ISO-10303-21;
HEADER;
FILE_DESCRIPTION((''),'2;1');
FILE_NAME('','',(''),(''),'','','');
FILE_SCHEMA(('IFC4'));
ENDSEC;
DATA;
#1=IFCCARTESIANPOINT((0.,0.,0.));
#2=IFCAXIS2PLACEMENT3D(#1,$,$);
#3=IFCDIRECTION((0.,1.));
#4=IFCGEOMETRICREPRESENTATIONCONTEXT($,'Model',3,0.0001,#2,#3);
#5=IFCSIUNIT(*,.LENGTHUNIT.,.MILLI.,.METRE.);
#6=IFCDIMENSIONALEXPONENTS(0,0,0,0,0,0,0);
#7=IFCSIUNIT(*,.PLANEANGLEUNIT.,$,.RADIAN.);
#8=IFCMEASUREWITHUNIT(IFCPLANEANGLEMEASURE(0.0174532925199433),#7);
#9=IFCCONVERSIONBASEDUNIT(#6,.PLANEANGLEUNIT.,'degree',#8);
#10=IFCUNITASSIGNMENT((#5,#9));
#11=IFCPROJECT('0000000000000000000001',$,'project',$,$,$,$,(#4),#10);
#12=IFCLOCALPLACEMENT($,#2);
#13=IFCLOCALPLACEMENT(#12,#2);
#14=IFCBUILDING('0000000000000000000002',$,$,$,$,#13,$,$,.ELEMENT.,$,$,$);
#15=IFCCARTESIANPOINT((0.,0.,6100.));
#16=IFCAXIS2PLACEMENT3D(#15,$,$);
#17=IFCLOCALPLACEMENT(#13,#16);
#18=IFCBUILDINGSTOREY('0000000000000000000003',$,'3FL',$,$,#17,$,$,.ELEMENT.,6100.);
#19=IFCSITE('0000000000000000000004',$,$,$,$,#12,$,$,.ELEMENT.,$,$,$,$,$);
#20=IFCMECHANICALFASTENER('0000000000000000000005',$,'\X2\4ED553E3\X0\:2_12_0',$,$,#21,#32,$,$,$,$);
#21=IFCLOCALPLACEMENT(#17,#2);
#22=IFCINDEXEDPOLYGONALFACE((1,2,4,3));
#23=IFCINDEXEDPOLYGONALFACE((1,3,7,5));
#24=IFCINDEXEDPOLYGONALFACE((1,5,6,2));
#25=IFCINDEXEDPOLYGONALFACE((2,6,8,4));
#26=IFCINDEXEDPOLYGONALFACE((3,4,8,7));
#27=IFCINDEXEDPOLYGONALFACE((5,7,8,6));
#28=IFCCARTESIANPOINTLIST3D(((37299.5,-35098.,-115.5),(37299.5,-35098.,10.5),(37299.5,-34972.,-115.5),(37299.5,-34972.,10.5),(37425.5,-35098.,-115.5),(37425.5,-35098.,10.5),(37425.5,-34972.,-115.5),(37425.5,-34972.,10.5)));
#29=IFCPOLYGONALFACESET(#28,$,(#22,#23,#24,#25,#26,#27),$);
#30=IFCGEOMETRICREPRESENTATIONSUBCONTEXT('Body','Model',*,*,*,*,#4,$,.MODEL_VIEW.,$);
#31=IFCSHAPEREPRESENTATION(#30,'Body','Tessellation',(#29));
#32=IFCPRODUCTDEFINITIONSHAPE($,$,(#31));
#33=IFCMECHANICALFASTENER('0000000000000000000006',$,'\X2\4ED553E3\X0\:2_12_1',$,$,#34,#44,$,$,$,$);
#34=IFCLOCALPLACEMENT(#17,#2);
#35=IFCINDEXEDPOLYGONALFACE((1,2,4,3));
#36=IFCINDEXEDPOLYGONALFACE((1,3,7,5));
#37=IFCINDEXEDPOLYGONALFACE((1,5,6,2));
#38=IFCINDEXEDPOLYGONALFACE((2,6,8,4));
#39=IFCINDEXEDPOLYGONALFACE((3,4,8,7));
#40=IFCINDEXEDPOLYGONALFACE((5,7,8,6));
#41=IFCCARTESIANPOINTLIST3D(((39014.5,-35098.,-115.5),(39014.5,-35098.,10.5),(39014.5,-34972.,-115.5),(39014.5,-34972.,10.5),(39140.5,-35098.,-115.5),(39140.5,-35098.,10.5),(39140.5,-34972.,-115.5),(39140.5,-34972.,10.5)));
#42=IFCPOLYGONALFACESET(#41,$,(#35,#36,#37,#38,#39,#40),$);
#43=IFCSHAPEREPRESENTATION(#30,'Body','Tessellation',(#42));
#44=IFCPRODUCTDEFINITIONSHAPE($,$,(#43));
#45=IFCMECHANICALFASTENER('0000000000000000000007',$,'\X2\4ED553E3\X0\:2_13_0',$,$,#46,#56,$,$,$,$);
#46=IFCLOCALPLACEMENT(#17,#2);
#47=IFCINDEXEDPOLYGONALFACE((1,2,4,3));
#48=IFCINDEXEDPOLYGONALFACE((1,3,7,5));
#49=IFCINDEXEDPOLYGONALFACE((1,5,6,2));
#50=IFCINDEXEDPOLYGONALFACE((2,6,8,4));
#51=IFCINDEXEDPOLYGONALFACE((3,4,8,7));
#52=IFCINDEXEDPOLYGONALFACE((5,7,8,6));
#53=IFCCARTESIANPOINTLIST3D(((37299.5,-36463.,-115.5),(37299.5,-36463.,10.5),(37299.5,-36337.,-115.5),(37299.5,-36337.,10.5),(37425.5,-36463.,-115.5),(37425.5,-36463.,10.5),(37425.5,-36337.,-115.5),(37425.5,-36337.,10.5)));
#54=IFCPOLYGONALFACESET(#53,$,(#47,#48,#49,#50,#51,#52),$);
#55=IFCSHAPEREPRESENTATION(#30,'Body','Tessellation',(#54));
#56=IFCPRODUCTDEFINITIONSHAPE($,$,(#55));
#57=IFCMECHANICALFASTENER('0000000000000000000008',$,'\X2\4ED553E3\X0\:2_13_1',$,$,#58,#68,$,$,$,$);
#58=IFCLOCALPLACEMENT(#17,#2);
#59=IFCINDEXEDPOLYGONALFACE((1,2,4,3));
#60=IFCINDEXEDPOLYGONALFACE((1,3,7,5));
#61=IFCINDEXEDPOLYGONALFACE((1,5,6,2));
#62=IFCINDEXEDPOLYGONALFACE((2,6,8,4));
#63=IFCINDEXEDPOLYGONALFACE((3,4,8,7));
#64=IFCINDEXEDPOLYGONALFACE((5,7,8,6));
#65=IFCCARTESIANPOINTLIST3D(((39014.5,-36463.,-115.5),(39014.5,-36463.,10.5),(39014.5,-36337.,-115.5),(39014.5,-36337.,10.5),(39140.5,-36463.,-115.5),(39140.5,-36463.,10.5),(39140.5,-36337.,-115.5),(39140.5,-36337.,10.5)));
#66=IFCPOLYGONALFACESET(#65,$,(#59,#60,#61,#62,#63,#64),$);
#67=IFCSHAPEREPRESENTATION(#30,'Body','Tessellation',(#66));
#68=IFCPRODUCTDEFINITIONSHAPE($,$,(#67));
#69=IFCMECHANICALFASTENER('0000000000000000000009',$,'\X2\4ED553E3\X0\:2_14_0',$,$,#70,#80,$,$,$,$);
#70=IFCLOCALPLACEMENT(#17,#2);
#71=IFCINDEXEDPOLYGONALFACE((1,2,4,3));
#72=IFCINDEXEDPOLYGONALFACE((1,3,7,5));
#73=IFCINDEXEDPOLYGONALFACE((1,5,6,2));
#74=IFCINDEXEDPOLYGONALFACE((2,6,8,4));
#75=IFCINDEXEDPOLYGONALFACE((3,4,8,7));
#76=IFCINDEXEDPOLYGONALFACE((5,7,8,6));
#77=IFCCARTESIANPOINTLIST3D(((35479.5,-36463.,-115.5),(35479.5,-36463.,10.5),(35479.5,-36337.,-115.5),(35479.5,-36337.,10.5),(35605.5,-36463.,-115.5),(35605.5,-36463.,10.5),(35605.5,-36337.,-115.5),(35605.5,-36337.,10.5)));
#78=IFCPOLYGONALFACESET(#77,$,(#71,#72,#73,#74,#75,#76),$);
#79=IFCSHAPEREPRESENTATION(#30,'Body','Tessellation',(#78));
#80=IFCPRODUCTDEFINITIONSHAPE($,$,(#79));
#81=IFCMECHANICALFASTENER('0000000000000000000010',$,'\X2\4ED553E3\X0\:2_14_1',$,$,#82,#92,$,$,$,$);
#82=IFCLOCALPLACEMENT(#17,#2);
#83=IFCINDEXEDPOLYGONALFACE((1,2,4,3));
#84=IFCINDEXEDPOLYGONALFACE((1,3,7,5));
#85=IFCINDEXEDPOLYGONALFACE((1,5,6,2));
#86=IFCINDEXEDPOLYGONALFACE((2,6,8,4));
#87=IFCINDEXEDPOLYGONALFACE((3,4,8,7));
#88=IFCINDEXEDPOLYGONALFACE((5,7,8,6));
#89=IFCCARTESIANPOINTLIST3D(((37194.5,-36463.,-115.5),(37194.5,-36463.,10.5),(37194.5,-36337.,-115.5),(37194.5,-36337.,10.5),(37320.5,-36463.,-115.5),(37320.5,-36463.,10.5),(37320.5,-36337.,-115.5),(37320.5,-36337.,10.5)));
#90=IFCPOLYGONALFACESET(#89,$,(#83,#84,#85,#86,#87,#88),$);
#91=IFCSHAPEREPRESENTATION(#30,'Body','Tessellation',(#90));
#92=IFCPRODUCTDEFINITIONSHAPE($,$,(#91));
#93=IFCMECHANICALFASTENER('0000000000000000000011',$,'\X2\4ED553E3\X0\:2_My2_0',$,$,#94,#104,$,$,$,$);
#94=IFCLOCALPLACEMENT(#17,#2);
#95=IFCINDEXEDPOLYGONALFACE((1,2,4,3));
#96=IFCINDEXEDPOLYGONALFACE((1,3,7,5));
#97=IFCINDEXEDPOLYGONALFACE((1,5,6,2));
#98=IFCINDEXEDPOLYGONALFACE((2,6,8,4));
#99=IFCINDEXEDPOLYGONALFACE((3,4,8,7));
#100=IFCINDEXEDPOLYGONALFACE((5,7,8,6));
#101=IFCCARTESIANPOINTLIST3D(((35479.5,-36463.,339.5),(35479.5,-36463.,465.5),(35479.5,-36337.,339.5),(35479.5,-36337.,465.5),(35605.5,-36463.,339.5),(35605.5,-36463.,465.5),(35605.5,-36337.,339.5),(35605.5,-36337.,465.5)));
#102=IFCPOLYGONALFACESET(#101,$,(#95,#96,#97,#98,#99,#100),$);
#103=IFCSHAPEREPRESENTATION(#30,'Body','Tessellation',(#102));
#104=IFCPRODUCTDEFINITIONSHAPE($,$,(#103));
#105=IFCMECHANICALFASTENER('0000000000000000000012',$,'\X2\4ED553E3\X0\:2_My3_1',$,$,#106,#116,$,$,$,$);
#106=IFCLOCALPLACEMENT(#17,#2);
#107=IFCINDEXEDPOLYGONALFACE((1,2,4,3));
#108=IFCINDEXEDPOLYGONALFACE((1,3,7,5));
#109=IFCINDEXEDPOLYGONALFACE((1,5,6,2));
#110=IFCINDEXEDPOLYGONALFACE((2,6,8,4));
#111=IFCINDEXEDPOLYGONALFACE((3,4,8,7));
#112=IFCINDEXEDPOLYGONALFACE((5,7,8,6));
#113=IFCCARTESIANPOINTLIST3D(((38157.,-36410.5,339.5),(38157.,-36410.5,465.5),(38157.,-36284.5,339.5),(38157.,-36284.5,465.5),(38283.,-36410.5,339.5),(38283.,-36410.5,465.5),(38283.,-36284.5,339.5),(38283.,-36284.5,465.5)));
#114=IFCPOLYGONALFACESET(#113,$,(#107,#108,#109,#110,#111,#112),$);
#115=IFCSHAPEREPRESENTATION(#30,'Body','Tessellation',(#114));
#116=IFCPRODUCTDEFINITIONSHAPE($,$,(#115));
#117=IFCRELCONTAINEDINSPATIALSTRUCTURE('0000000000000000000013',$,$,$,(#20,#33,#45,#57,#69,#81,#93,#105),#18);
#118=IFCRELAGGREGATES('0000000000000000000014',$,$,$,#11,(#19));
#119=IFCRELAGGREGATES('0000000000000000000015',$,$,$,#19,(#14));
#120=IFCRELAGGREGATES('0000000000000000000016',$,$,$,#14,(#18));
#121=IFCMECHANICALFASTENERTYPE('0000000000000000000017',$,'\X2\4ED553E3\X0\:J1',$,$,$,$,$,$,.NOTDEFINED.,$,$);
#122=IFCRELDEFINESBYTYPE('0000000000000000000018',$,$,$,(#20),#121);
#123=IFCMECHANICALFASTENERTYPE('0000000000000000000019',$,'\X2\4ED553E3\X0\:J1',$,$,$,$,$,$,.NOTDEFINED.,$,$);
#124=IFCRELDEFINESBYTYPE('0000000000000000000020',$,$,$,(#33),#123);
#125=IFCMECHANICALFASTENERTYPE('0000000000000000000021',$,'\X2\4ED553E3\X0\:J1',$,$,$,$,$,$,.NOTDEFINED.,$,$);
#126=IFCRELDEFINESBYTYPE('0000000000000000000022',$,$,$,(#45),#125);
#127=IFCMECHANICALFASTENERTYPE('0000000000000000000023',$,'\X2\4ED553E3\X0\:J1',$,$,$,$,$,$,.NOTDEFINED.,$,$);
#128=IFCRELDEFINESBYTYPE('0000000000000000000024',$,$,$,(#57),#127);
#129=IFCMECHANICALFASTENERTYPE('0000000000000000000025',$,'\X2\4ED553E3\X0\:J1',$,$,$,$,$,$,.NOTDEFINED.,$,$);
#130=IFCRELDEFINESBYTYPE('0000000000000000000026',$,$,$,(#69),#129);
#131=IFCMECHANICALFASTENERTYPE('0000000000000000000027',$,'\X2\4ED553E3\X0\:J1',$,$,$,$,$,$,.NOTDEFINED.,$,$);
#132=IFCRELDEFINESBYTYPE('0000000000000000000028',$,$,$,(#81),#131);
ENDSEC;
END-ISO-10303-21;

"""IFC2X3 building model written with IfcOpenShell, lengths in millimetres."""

from ifc_helpers import new_model, entity, si_unit, converted_unit, direction, frame, origin, origin_with_axes, origin_2d, place, context, subcontext, project, spatial, rectangle, extrude, type_object, element, save


model = new_model("IFC2X3")

# Units and contexts
model_context = context("Model", 3, precision=0.0001, world=origin(), true_north=direction((0.0, 1.0)))
body_context = subcontext(model_context, "Body", "Model", "MODEL_VIEW")
ifc_project = project(units=[si_unit("LENGTHUNIT", "METRE", prefix="MILLI"), converted_unit("PLANEANGLEUNIT", "degree", entity("IfcPlaneAngleMeasure", 0.0174532925199433), si_unit("PLANEANGLEUNIT", "RADIAN"), dimensions=[0, 0, 0, 0, 0, 0, 0])], contexts=[model_context])

# Site, building, storey
site_placement = place(None, origin())
site = spatial("IfcSite", under=ifc_project, at=site_placement, CompositionType="ELEMENT")
building_placement = place(site_placement, origin())
building = spatial("IfcBuilding", under=site, at=building_placement, CompositionType="ELEMENT")
storey_placement = place(building_placement, frame((0.0, 0.0, 6100.0)))
storey = spatial("IfcBuildingStorey", under=building, at=storey_placement, Name="3FL", CompositionType="ELEMENT", Elevation=6100.0)

# Mechanical fasteners
mechanical_fastener_type_1 = type_object("IfcMechanicalFastenerType", Name="仕口:J1")
mechanical_fastener_1_placement = place(storey_placement, frame((37362.5, -35035.0, -115.5)))
element("IfcMechanicalFastener", 1, at=mechanical_fastener_1_placement, inside=storey, type_object=mechanical_fastener_type_1, Name="仕口:2_12_0", context=body_context, shape_type="SweptSolid", body=[
    extrude(rectangle(XDim=126.0, YDim=126.0, at=origin_2d()), origin_with_axes(), (0.0, 0.0, 1.0), 126.0),
])
mechanical_fastener_type_2 = type_object("IfcMechanicalFastenerType", Name="仕口:J1")
mechanical_fastener_2_placement = place(storey_placement, frame((39077.5, -35035.0, -115.5)))
element("IfcMechanicalFastener", 2, at=mechanical_fastener_2_placement, inside=storey, type_object=mechanical_fastener_type_2, Name="仕口:2_12_1", context=body_context, shape_type="SweptSolid", body=[
    extrude(rectangle(XDim=126.0, YDim=126.0, at=origin_2d()), origin_with_axes(), (0.0, 0.0, 1.0), 126.0),
])
mechanical_fastener_type_3 = type_object("IfcMechanicalFastenerType", Name="仕口:J1")
mechanical_fastener_3_placement = place(storey_placement, frame((37362.5, -36400.0, -115.5)))
element("IfcMechanicalFastener", 3, at=mechanical_fastener_3_placement, inside=storey, type_object=mechanical_fastener_type_3, Name="仕口:2_13_0", context=body_context, shape_type="SweptSolid", body=[
    extrude(rectangle(XDim=126.0, YDim=126.0, at=origin_2d()), origin_with_axes(), (0.0, 0.0, 1.0), 126.0),
])
mechanical_fastener_type_4 = type_object("IfcMechanicalFastenerType", Name="仕口:J1")
mechanical_fastener_4_placement = place(storey_placement, frame((39077.5, -36400.0, -115.5)))
element("IfcMechanicalFastener", 4, at=mechanical_fastener_4_placement, inside=storey, type_object=mechanical_fastener_type_4, Name="仕口:2_13_1", context=body_context, shape_type="SweptSolid", body=[
    extrude(rectangle(XDim=126.0, YDim=126.0, at=origin_2d()), origin_with_axes(), (0.0, 0.0, 1.0), 126.0),
])
mechanical_fastener_type_5 = type_object("IfcMechanicalFastenerType", Name="仕口:J1")
mechanical_fastener_5_placement = place(storey_placement, frame((35542.5, -36400.0, -115.5)))
element("IfcMechanicalFastener", 5, at=mechanical_fastener_5_placement, inside=storey, type_object=mechanical_fastener_type_5, Name="仕口:2_14_0", context=body_context, shape_type="SweptSolid", body=[
    extrude(rectangle(XDim=126.0, YDim=126.0, at=origin_2d()), origin_with_axes(), (0.0, 0.0, 1.0), 126.0),
])
mechanical_fastener_type_6 = type_object("IfcMechanicalFastenerType", Name="仕口:J1")
mechanical_fastener_6_placement = place(storey_placement, frame((37257.5, -36400.0, -115.5)))
element("IfcMechanicalFastener", 6, at=mechanical_fastener_6_placement, inside=storey, type_object=mechanical_fastener_type_6, Name="仕口:2_14_1", context=body_context, shape_type="SweptSolid", body=[
    extrude(rectangle(XDim=126.0, YDim=126.0, at=origin_2d()), origin_with_axes(), (0.0, 0.0, 1.0), 126.0),
])
for number, where, name in (
    (7, (35542.5, -36400.0, 339.5), "仕口:2_My2_0"),
    (8, (38220.0, -36347.5, 339.5), "仕口:2_My3_1"),
):
    element("IfcMechanicalFastener", number, at=place(storey_placement, frame(where)), inside=storey, Name=name, context=body_context, shape_type="SweptSolid", body=[
        extrude(rectangle(XDim=126.0, YDim=126.0, at=origin_2d()), origin_with_axes(), (0.0, 0.0, 1.0), 126.0),
    ])

save(model, "model.ifc")
